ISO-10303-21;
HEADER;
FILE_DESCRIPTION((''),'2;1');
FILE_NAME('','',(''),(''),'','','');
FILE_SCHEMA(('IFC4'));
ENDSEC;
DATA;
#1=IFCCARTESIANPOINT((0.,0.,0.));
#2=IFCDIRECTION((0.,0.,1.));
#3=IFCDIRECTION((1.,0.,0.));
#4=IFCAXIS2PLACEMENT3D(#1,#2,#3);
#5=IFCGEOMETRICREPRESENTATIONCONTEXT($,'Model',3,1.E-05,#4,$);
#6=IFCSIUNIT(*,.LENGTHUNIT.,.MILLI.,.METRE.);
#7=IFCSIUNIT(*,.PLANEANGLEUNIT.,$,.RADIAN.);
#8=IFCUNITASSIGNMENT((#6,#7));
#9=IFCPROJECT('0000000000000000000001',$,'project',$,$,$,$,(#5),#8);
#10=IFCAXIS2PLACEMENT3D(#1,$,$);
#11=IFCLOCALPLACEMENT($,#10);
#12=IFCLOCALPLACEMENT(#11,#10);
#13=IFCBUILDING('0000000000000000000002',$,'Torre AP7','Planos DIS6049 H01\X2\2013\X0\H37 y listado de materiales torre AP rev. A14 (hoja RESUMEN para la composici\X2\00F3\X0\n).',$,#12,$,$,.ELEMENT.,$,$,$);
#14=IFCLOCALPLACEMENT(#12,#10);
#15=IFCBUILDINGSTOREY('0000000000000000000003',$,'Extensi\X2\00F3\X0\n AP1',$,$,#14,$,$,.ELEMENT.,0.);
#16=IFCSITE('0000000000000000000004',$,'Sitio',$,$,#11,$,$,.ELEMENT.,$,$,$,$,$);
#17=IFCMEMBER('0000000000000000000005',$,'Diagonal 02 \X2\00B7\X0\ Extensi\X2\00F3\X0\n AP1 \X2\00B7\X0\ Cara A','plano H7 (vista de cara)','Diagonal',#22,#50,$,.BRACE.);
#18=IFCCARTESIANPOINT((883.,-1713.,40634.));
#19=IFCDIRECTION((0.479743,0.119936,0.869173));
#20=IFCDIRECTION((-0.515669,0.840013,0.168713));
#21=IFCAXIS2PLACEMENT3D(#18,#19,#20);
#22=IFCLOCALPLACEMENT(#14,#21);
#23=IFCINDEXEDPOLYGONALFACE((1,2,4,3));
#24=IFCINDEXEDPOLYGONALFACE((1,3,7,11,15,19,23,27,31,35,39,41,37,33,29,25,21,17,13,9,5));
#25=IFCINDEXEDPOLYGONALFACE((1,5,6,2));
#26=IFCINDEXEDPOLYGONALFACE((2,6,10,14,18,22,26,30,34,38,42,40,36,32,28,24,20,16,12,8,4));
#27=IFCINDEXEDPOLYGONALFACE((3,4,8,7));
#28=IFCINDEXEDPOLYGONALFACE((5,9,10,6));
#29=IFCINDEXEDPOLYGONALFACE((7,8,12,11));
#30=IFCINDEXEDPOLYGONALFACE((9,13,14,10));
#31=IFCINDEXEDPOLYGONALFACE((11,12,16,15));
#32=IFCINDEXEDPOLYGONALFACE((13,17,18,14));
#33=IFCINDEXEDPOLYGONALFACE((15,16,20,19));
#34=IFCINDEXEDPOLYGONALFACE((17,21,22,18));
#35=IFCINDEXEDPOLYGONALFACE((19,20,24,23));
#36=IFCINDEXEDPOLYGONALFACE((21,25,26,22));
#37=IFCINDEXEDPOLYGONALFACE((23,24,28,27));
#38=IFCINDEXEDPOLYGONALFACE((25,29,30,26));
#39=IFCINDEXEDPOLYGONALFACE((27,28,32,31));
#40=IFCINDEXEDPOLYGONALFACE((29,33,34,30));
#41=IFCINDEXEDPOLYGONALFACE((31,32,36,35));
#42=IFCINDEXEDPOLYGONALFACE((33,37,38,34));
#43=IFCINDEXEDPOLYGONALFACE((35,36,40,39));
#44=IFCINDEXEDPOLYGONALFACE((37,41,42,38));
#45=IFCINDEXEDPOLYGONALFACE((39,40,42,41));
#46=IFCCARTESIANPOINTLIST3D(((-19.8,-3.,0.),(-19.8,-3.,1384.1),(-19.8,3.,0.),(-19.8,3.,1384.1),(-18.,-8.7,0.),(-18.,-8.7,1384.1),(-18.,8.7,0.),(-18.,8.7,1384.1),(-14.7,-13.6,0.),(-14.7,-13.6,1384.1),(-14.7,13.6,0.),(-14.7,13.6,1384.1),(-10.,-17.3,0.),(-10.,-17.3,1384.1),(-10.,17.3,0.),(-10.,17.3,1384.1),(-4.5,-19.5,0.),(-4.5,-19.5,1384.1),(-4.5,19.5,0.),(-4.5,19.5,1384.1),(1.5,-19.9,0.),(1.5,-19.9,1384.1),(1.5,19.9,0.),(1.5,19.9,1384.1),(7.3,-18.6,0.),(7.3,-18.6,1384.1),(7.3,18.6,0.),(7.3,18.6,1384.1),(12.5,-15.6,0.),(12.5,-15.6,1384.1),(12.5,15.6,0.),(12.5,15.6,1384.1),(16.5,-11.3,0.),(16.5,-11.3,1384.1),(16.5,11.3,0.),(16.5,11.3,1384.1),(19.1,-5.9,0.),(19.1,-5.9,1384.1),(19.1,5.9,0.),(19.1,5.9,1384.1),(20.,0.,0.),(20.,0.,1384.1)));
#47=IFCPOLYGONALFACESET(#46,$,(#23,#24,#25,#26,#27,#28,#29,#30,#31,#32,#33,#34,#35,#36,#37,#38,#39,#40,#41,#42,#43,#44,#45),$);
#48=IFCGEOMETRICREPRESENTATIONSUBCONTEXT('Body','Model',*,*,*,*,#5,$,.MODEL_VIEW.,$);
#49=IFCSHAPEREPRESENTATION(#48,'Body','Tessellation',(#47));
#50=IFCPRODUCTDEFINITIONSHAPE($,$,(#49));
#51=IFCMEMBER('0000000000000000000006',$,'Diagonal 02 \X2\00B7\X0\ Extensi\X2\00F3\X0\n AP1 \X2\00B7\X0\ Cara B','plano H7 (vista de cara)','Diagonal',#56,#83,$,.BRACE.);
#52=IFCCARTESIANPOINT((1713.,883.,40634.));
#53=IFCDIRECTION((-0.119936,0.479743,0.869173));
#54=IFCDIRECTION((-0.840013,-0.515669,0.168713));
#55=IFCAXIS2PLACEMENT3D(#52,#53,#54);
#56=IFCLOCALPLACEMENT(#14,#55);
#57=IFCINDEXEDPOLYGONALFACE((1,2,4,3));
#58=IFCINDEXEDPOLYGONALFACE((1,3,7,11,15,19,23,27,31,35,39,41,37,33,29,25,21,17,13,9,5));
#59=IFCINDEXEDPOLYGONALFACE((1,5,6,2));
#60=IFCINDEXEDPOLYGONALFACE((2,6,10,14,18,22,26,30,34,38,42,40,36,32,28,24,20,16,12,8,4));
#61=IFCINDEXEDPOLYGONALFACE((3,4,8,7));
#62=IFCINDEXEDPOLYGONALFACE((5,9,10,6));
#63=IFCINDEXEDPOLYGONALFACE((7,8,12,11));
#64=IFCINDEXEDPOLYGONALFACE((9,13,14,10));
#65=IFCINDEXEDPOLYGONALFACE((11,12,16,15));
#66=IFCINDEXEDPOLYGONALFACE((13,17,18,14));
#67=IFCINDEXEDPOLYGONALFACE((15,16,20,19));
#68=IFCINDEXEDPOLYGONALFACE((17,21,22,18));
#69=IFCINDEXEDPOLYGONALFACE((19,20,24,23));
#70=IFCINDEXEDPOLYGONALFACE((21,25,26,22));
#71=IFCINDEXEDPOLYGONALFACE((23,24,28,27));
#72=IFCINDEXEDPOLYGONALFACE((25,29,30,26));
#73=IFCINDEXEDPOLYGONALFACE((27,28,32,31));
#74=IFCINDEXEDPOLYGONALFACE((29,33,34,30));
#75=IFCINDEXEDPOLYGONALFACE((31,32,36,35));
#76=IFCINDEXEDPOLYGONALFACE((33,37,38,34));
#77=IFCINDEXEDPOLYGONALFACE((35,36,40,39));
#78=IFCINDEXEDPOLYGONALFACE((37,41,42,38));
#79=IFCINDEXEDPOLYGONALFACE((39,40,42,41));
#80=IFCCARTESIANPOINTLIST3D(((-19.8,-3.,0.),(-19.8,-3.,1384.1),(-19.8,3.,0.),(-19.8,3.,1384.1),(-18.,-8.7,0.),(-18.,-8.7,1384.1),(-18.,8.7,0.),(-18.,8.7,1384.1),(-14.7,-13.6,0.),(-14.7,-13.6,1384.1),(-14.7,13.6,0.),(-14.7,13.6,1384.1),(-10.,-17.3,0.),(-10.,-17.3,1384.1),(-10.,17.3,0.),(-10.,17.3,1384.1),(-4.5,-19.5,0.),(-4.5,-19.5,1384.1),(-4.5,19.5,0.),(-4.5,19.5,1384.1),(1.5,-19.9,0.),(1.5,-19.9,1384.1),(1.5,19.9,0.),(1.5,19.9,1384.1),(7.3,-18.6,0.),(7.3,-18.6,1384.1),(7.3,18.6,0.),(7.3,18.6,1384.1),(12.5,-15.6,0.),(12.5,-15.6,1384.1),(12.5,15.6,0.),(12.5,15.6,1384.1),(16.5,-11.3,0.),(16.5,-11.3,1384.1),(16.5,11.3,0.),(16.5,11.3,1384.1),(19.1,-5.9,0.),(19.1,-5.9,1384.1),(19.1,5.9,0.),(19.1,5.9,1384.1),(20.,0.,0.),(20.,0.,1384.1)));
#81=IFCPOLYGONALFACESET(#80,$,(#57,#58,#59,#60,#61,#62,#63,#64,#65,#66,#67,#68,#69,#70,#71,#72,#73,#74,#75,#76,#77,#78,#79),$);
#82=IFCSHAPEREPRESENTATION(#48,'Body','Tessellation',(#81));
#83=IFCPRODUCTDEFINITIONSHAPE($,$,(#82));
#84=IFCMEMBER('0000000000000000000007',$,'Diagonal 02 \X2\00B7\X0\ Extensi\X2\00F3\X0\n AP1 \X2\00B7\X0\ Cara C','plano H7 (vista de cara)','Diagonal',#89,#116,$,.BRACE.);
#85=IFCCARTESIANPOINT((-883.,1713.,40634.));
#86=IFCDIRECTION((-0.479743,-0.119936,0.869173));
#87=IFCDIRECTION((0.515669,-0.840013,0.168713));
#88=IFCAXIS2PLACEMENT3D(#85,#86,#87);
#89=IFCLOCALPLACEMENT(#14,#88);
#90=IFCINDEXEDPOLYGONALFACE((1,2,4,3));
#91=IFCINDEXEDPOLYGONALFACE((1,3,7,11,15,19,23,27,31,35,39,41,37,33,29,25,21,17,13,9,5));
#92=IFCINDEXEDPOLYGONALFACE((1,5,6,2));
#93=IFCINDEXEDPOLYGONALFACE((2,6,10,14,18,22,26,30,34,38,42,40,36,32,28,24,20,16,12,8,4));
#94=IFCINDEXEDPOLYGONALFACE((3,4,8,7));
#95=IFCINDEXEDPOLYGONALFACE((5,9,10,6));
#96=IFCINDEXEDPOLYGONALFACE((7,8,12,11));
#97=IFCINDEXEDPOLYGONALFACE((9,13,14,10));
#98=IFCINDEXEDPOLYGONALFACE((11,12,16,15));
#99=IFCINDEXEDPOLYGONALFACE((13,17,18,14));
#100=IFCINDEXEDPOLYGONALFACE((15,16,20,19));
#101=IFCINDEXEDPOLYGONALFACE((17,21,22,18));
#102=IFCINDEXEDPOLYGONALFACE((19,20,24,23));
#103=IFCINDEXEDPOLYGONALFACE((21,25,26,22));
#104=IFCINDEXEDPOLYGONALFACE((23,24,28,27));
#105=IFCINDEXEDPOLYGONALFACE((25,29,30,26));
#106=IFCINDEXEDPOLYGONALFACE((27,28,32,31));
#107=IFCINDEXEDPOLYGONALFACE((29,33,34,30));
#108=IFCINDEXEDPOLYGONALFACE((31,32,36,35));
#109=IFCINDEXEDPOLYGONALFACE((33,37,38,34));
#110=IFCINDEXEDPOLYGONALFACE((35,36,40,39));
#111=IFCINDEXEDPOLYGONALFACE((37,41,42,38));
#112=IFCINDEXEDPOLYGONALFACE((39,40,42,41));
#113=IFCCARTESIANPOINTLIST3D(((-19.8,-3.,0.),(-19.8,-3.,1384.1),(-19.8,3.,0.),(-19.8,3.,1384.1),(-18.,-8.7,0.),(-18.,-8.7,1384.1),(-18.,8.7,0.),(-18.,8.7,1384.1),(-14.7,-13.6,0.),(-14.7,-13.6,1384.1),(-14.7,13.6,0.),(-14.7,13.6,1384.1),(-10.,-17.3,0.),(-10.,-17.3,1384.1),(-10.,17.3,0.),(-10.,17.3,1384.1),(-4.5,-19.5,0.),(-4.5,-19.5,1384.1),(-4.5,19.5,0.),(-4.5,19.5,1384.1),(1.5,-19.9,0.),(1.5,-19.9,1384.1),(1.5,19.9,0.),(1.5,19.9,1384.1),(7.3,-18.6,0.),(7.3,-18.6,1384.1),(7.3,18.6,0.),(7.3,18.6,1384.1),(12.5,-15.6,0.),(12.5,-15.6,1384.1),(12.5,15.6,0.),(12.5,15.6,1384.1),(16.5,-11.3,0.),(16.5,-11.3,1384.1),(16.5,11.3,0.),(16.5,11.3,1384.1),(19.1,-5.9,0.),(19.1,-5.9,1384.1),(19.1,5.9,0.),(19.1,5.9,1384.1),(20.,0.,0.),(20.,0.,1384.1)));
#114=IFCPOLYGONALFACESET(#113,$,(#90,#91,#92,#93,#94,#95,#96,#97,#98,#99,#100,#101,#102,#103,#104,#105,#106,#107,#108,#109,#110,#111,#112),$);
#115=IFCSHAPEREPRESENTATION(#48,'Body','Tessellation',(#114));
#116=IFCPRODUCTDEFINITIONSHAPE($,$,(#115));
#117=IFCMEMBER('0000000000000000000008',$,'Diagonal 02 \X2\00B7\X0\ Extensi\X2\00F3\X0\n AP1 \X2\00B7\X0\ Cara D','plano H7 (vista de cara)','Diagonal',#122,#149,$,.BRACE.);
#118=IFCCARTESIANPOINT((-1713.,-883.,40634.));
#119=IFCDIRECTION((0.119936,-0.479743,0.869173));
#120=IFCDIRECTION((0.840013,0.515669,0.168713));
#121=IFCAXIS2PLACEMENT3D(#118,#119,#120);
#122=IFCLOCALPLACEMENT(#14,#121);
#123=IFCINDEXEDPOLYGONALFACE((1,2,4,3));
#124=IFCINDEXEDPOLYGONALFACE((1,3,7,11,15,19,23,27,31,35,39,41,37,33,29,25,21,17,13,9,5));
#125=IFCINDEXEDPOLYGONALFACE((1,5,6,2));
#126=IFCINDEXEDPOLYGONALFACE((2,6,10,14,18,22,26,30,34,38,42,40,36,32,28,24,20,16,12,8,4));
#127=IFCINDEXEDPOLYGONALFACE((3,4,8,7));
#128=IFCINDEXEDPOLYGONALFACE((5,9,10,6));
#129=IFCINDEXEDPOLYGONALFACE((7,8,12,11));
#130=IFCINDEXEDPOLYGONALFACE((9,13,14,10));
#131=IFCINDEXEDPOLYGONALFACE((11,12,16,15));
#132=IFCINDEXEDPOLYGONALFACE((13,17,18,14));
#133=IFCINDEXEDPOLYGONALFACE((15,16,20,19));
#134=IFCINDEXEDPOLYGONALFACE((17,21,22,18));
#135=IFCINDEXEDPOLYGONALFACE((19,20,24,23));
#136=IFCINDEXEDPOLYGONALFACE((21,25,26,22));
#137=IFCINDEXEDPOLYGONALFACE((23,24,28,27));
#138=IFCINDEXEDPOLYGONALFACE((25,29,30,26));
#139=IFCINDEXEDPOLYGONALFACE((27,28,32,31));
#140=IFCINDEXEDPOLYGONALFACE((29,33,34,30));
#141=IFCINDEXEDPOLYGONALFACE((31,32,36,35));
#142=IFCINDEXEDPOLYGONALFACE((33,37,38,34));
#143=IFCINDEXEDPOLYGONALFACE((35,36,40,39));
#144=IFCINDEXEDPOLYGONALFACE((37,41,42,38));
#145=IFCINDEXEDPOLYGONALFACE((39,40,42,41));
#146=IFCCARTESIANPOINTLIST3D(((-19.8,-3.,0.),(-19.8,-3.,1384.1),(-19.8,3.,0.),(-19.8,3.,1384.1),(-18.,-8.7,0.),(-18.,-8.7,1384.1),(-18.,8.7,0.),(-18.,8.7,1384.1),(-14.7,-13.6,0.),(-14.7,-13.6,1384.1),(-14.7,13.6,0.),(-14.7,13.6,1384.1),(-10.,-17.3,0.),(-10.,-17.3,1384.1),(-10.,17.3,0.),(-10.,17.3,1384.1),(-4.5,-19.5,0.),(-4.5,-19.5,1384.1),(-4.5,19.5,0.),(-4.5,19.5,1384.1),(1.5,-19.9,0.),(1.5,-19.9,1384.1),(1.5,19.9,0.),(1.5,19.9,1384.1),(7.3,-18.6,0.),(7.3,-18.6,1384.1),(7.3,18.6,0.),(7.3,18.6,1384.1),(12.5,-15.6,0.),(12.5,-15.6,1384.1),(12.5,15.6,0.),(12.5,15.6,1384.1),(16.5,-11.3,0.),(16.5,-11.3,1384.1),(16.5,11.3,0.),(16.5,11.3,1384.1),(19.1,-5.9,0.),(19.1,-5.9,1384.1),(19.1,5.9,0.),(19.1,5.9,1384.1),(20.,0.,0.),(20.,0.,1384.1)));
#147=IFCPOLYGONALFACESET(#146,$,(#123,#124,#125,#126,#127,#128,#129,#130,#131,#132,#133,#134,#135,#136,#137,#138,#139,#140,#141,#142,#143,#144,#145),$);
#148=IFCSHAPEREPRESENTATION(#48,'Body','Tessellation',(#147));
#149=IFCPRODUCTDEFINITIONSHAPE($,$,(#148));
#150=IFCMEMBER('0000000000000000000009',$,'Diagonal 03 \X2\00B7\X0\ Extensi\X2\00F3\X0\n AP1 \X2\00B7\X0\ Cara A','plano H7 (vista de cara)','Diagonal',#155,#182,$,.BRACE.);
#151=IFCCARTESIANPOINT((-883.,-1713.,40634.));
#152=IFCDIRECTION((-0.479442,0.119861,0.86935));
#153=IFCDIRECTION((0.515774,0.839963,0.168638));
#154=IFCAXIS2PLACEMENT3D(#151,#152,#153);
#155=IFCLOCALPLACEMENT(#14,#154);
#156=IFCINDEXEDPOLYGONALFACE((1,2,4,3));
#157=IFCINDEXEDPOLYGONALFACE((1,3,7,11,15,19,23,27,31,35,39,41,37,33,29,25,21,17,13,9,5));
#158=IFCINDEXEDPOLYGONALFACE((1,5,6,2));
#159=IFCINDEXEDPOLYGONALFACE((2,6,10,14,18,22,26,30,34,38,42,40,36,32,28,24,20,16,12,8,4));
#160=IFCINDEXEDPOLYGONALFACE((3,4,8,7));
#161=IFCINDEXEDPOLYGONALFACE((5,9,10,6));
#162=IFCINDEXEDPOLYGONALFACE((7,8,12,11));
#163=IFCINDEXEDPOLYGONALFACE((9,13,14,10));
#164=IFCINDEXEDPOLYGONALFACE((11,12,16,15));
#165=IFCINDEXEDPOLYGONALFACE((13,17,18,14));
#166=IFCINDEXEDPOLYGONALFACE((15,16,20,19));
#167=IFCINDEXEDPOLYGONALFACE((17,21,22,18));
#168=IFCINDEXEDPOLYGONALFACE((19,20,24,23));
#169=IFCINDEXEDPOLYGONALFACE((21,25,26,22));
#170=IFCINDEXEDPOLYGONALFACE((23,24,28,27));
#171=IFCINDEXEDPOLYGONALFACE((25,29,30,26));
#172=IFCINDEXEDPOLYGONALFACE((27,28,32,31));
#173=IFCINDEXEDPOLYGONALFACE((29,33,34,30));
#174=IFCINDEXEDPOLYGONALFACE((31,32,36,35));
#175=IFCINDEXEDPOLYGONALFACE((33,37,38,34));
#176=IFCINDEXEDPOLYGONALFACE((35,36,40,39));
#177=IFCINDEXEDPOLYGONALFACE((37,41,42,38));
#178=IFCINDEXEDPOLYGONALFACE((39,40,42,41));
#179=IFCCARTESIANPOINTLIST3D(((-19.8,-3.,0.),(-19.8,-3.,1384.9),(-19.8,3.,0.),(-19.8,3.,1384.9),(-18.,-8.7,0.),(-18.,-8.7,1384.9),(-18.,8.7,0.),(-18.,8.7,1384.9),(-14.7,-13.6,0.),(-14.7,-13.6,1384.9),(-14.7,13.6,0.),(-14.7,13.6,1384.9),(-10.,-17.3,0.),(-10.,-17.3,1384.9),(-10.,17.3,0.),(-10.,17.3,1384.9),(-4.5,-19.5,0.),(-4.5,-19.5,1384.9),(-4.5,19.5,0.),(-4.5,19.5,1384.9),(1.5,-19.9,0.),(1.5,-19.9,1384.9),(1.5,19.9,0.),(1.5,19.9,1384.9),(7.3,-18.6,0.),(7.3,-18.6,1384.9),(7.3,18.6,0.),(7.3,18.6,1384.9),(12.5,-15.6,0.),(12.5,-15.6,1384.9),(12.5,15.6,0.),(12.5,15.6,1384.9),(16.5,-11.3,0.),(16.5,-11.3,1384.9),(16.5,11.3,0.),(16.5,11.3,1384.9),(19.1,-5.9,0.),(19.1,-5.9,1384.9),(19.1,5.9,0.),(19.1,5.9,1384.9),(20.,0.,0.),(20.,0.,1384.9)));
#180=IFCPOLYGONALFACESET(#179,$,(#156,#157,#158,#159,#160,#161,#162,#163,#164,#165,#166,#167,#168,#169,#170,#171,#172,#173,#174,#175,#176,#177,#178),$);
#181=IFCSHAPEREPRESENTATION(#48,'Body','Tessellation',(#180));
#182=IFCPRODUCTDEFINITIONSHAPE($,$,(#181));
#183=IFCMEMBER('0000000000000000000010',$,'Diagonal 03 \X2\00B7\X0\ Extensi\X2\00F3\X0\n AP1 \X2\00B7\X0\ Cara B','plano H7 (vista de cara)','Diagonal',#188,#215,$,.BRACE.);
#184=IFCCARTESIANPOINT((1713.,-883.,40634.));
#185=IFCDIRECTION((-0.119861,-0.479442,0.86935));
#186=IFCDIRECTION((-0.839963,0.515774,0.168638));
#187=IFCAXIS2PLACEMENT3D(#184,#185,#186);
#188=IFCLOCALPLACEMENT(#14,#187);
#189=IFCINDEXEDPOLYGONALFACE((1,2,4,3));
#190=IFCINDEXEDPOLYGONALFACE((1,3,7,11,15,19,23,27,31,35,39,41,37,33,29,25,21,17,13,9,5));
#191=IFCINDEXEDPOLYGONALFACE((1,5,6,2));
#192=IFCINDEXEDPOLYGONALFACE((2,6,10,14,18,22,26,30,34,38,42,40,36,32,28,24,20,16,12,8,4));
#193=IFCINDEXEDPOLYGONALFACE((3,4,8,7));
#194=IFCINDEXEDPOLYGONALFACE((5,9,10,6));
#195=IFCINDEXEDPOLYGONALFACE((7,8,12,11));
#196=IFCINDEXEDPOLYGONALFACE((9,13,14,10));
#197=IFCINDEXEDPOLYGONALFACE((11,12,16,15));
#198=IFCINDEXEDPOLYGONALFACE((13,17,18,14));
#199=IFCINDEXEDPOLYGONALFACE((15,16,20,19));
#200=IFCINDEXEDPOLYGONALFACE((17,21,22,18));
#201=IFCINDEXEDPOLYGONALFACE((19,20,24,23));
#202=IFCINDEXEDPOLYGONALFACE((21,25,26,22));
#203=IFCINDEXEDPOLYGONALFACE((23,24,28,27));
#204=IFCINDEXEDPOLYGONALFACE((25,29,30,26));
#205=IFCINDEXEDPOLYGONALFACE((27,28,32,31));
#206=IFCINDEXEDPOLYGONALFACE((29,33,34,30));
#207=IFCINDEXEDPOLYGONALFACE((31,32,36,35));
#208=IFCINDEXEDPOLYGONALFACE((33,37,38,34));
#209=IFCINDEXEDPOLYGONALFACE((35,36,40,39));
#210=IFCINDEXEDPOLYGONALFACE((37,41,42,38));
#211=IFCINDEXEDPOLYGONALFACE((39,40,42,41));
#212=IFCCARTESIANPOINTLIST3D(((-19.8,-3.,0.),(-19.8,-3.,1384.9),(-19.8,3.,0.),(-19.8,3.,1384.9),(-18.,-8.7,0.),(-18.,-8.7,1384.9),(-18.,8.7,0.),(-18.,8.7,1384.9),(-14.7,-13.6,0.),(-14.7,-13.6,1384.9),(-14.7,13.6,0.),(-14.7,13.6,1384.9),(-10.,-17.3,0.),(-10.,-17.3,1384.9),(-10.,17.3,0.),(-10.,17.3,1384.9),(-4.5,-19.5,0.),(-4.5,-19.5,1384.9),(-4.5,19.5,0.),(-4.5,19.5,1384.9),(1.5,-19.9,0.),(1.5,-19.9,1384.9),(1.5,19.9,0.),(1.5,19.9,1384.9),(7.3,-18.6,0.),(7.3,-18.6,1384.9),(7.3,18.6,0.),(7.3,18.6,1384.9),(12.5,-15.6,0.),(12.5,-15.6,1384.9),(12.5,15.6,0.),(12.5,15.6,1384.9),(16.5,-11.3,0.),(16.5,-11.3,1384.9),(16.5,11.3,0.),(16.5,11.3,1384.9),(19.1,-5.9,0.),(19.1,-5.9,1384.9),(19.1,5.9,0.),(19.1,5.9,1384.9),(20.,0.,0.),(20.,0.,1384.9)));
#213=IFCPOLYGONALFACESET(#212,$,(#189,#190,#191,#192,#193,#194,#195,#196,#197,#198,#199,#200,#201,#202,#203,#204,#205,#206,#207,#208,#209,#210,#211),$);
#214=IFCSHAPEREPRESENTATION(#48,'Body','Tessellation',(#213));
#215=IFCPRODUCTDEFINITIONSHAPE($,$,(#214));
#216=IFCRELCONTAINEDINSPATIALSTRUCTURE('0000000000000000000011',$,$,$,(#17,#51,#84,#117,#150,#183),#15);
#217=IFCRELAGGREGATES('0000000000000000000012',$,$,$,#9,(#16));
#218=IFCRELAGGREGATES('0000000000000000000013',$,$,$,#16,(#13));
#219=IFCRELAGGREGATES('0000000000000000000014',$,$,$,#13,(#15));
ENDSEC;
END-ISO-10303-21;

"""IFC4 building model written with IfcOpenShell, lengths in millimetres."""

from ifc_helpers import new_model, si_unit, frame, origin, origin_with_axes, place, context, subcontext, project, spatial, circle, extrude, element, save


model = new_model("IFC4")

# Units and contexts
model_context = context("Model", 3, precision=1e-05, world=origin_with_axes())
body_context = subcontext(model_context, "Body", "Model", "MODEL_VIEW")
ifc_project = project(units=[si_unit("LENGTHUNIT", "METRE", prefix="MILLI"), si_unit("PLANEANGLEUNIT", "RADIAN")], contexts=[model_context])

# Site, building, storey
site_placement = place(None, origin())
site = spatial("IfcSite", under=ifc_project, at=site_placement, Name="Sitio", CompositionType="ELEMENT")
building_placement = place(site_placement, origin())
building = spatial("IfcBuilding", under=site, at=building_placement, Name="Torre AP7", Description="Planos DIS6049 H01–H37 y listado de materiales torre AP rev. A14 (hoja RESUMEN para la composición).", CompositionType="ELEMENT")
storey_placement = place(building_placement, origin())
storey = spatial("IfcBuildingStorey", under=building, at=storey_placement, Name="Extensión AP1", CompositionType="ELEMENT", Elevation=0.0)

# Members
for number, where, z_axis, x_axis, name in (
    (1, (883.0, -1713.0, 40634.0), (0.479743, 0.119936, 0.869173), (-0.515669, 0.840013, 0.168713), "Diagonal 02 · Extensión AP1 · Cara A"),
    (2, (1713.0, 883.0, 40634.0), (-0.119936, 0.479743, 0.869173), (-0.840013, -0.515669, 0.168713), "Diagonal 02 · Extensión AP1 · Cara B"),
    (3, (-883.0, 1713.0, 40634.0), (-0.479743, -0.119936, 0.869173), (0.515669, -0.840013, 0.168713), "Diagonal 02 · Extensión AP1 · Cara C"),
    (4, (-1713.0, -883.0, 40634.0), (0.119936, -0.479743, 0.869173), (0.840013, 0.515669, 0.168713), "Diagonal 02 · Extensión AP1 · Cara D"),
):
    element("IfcMember", number, at=place(storey_placement, frame(where, z_axis=z_axis, x_axis=x_axis)), inside=storey, Name=name, Description="plano H7 (vista de cara)", ObjectType="Diagonal", PredefinedType="BRACE", context=body_context, shape_type="SweptSolid", body=[
        extrude(circle(Radius=20.0), None, (0.0, 0.0, 1.0), 1384.1),
    ])
for number, where, z_axis, x_axis, name in (
    (5, (-883.0, -1713.0, 40634.0), (-0.479442, 0.119861, 0.86935), (0.515774, 0.839963, 0.168638), "Diagonal 03 · Extensión AP1 · Cara A"),
    (6, (1713.0, -883.0, 40634.0), (-0.119861, -0.479442, 0.86935), (-0.839963, 0.515774, 0.168638), "Diagonal 03 · Extensión AP1 · Cara B"),
):
    element("IfcMember", number, at=place(storey_placement, frame(where, z_axis=z_axis, x_axis=x_axis)), inside=storey, Name=name, Description="plano H7 (vista de cara)", ObjectType="Diagonal", PredefinedType="BRACE", context=body_context, shape_type="SweptSolid", body=[
        extrude(circle(Radius=20.0), None, (0.0, 0.0, 1.0), 1384.9),
    ])

save(model, "model.ifc")
